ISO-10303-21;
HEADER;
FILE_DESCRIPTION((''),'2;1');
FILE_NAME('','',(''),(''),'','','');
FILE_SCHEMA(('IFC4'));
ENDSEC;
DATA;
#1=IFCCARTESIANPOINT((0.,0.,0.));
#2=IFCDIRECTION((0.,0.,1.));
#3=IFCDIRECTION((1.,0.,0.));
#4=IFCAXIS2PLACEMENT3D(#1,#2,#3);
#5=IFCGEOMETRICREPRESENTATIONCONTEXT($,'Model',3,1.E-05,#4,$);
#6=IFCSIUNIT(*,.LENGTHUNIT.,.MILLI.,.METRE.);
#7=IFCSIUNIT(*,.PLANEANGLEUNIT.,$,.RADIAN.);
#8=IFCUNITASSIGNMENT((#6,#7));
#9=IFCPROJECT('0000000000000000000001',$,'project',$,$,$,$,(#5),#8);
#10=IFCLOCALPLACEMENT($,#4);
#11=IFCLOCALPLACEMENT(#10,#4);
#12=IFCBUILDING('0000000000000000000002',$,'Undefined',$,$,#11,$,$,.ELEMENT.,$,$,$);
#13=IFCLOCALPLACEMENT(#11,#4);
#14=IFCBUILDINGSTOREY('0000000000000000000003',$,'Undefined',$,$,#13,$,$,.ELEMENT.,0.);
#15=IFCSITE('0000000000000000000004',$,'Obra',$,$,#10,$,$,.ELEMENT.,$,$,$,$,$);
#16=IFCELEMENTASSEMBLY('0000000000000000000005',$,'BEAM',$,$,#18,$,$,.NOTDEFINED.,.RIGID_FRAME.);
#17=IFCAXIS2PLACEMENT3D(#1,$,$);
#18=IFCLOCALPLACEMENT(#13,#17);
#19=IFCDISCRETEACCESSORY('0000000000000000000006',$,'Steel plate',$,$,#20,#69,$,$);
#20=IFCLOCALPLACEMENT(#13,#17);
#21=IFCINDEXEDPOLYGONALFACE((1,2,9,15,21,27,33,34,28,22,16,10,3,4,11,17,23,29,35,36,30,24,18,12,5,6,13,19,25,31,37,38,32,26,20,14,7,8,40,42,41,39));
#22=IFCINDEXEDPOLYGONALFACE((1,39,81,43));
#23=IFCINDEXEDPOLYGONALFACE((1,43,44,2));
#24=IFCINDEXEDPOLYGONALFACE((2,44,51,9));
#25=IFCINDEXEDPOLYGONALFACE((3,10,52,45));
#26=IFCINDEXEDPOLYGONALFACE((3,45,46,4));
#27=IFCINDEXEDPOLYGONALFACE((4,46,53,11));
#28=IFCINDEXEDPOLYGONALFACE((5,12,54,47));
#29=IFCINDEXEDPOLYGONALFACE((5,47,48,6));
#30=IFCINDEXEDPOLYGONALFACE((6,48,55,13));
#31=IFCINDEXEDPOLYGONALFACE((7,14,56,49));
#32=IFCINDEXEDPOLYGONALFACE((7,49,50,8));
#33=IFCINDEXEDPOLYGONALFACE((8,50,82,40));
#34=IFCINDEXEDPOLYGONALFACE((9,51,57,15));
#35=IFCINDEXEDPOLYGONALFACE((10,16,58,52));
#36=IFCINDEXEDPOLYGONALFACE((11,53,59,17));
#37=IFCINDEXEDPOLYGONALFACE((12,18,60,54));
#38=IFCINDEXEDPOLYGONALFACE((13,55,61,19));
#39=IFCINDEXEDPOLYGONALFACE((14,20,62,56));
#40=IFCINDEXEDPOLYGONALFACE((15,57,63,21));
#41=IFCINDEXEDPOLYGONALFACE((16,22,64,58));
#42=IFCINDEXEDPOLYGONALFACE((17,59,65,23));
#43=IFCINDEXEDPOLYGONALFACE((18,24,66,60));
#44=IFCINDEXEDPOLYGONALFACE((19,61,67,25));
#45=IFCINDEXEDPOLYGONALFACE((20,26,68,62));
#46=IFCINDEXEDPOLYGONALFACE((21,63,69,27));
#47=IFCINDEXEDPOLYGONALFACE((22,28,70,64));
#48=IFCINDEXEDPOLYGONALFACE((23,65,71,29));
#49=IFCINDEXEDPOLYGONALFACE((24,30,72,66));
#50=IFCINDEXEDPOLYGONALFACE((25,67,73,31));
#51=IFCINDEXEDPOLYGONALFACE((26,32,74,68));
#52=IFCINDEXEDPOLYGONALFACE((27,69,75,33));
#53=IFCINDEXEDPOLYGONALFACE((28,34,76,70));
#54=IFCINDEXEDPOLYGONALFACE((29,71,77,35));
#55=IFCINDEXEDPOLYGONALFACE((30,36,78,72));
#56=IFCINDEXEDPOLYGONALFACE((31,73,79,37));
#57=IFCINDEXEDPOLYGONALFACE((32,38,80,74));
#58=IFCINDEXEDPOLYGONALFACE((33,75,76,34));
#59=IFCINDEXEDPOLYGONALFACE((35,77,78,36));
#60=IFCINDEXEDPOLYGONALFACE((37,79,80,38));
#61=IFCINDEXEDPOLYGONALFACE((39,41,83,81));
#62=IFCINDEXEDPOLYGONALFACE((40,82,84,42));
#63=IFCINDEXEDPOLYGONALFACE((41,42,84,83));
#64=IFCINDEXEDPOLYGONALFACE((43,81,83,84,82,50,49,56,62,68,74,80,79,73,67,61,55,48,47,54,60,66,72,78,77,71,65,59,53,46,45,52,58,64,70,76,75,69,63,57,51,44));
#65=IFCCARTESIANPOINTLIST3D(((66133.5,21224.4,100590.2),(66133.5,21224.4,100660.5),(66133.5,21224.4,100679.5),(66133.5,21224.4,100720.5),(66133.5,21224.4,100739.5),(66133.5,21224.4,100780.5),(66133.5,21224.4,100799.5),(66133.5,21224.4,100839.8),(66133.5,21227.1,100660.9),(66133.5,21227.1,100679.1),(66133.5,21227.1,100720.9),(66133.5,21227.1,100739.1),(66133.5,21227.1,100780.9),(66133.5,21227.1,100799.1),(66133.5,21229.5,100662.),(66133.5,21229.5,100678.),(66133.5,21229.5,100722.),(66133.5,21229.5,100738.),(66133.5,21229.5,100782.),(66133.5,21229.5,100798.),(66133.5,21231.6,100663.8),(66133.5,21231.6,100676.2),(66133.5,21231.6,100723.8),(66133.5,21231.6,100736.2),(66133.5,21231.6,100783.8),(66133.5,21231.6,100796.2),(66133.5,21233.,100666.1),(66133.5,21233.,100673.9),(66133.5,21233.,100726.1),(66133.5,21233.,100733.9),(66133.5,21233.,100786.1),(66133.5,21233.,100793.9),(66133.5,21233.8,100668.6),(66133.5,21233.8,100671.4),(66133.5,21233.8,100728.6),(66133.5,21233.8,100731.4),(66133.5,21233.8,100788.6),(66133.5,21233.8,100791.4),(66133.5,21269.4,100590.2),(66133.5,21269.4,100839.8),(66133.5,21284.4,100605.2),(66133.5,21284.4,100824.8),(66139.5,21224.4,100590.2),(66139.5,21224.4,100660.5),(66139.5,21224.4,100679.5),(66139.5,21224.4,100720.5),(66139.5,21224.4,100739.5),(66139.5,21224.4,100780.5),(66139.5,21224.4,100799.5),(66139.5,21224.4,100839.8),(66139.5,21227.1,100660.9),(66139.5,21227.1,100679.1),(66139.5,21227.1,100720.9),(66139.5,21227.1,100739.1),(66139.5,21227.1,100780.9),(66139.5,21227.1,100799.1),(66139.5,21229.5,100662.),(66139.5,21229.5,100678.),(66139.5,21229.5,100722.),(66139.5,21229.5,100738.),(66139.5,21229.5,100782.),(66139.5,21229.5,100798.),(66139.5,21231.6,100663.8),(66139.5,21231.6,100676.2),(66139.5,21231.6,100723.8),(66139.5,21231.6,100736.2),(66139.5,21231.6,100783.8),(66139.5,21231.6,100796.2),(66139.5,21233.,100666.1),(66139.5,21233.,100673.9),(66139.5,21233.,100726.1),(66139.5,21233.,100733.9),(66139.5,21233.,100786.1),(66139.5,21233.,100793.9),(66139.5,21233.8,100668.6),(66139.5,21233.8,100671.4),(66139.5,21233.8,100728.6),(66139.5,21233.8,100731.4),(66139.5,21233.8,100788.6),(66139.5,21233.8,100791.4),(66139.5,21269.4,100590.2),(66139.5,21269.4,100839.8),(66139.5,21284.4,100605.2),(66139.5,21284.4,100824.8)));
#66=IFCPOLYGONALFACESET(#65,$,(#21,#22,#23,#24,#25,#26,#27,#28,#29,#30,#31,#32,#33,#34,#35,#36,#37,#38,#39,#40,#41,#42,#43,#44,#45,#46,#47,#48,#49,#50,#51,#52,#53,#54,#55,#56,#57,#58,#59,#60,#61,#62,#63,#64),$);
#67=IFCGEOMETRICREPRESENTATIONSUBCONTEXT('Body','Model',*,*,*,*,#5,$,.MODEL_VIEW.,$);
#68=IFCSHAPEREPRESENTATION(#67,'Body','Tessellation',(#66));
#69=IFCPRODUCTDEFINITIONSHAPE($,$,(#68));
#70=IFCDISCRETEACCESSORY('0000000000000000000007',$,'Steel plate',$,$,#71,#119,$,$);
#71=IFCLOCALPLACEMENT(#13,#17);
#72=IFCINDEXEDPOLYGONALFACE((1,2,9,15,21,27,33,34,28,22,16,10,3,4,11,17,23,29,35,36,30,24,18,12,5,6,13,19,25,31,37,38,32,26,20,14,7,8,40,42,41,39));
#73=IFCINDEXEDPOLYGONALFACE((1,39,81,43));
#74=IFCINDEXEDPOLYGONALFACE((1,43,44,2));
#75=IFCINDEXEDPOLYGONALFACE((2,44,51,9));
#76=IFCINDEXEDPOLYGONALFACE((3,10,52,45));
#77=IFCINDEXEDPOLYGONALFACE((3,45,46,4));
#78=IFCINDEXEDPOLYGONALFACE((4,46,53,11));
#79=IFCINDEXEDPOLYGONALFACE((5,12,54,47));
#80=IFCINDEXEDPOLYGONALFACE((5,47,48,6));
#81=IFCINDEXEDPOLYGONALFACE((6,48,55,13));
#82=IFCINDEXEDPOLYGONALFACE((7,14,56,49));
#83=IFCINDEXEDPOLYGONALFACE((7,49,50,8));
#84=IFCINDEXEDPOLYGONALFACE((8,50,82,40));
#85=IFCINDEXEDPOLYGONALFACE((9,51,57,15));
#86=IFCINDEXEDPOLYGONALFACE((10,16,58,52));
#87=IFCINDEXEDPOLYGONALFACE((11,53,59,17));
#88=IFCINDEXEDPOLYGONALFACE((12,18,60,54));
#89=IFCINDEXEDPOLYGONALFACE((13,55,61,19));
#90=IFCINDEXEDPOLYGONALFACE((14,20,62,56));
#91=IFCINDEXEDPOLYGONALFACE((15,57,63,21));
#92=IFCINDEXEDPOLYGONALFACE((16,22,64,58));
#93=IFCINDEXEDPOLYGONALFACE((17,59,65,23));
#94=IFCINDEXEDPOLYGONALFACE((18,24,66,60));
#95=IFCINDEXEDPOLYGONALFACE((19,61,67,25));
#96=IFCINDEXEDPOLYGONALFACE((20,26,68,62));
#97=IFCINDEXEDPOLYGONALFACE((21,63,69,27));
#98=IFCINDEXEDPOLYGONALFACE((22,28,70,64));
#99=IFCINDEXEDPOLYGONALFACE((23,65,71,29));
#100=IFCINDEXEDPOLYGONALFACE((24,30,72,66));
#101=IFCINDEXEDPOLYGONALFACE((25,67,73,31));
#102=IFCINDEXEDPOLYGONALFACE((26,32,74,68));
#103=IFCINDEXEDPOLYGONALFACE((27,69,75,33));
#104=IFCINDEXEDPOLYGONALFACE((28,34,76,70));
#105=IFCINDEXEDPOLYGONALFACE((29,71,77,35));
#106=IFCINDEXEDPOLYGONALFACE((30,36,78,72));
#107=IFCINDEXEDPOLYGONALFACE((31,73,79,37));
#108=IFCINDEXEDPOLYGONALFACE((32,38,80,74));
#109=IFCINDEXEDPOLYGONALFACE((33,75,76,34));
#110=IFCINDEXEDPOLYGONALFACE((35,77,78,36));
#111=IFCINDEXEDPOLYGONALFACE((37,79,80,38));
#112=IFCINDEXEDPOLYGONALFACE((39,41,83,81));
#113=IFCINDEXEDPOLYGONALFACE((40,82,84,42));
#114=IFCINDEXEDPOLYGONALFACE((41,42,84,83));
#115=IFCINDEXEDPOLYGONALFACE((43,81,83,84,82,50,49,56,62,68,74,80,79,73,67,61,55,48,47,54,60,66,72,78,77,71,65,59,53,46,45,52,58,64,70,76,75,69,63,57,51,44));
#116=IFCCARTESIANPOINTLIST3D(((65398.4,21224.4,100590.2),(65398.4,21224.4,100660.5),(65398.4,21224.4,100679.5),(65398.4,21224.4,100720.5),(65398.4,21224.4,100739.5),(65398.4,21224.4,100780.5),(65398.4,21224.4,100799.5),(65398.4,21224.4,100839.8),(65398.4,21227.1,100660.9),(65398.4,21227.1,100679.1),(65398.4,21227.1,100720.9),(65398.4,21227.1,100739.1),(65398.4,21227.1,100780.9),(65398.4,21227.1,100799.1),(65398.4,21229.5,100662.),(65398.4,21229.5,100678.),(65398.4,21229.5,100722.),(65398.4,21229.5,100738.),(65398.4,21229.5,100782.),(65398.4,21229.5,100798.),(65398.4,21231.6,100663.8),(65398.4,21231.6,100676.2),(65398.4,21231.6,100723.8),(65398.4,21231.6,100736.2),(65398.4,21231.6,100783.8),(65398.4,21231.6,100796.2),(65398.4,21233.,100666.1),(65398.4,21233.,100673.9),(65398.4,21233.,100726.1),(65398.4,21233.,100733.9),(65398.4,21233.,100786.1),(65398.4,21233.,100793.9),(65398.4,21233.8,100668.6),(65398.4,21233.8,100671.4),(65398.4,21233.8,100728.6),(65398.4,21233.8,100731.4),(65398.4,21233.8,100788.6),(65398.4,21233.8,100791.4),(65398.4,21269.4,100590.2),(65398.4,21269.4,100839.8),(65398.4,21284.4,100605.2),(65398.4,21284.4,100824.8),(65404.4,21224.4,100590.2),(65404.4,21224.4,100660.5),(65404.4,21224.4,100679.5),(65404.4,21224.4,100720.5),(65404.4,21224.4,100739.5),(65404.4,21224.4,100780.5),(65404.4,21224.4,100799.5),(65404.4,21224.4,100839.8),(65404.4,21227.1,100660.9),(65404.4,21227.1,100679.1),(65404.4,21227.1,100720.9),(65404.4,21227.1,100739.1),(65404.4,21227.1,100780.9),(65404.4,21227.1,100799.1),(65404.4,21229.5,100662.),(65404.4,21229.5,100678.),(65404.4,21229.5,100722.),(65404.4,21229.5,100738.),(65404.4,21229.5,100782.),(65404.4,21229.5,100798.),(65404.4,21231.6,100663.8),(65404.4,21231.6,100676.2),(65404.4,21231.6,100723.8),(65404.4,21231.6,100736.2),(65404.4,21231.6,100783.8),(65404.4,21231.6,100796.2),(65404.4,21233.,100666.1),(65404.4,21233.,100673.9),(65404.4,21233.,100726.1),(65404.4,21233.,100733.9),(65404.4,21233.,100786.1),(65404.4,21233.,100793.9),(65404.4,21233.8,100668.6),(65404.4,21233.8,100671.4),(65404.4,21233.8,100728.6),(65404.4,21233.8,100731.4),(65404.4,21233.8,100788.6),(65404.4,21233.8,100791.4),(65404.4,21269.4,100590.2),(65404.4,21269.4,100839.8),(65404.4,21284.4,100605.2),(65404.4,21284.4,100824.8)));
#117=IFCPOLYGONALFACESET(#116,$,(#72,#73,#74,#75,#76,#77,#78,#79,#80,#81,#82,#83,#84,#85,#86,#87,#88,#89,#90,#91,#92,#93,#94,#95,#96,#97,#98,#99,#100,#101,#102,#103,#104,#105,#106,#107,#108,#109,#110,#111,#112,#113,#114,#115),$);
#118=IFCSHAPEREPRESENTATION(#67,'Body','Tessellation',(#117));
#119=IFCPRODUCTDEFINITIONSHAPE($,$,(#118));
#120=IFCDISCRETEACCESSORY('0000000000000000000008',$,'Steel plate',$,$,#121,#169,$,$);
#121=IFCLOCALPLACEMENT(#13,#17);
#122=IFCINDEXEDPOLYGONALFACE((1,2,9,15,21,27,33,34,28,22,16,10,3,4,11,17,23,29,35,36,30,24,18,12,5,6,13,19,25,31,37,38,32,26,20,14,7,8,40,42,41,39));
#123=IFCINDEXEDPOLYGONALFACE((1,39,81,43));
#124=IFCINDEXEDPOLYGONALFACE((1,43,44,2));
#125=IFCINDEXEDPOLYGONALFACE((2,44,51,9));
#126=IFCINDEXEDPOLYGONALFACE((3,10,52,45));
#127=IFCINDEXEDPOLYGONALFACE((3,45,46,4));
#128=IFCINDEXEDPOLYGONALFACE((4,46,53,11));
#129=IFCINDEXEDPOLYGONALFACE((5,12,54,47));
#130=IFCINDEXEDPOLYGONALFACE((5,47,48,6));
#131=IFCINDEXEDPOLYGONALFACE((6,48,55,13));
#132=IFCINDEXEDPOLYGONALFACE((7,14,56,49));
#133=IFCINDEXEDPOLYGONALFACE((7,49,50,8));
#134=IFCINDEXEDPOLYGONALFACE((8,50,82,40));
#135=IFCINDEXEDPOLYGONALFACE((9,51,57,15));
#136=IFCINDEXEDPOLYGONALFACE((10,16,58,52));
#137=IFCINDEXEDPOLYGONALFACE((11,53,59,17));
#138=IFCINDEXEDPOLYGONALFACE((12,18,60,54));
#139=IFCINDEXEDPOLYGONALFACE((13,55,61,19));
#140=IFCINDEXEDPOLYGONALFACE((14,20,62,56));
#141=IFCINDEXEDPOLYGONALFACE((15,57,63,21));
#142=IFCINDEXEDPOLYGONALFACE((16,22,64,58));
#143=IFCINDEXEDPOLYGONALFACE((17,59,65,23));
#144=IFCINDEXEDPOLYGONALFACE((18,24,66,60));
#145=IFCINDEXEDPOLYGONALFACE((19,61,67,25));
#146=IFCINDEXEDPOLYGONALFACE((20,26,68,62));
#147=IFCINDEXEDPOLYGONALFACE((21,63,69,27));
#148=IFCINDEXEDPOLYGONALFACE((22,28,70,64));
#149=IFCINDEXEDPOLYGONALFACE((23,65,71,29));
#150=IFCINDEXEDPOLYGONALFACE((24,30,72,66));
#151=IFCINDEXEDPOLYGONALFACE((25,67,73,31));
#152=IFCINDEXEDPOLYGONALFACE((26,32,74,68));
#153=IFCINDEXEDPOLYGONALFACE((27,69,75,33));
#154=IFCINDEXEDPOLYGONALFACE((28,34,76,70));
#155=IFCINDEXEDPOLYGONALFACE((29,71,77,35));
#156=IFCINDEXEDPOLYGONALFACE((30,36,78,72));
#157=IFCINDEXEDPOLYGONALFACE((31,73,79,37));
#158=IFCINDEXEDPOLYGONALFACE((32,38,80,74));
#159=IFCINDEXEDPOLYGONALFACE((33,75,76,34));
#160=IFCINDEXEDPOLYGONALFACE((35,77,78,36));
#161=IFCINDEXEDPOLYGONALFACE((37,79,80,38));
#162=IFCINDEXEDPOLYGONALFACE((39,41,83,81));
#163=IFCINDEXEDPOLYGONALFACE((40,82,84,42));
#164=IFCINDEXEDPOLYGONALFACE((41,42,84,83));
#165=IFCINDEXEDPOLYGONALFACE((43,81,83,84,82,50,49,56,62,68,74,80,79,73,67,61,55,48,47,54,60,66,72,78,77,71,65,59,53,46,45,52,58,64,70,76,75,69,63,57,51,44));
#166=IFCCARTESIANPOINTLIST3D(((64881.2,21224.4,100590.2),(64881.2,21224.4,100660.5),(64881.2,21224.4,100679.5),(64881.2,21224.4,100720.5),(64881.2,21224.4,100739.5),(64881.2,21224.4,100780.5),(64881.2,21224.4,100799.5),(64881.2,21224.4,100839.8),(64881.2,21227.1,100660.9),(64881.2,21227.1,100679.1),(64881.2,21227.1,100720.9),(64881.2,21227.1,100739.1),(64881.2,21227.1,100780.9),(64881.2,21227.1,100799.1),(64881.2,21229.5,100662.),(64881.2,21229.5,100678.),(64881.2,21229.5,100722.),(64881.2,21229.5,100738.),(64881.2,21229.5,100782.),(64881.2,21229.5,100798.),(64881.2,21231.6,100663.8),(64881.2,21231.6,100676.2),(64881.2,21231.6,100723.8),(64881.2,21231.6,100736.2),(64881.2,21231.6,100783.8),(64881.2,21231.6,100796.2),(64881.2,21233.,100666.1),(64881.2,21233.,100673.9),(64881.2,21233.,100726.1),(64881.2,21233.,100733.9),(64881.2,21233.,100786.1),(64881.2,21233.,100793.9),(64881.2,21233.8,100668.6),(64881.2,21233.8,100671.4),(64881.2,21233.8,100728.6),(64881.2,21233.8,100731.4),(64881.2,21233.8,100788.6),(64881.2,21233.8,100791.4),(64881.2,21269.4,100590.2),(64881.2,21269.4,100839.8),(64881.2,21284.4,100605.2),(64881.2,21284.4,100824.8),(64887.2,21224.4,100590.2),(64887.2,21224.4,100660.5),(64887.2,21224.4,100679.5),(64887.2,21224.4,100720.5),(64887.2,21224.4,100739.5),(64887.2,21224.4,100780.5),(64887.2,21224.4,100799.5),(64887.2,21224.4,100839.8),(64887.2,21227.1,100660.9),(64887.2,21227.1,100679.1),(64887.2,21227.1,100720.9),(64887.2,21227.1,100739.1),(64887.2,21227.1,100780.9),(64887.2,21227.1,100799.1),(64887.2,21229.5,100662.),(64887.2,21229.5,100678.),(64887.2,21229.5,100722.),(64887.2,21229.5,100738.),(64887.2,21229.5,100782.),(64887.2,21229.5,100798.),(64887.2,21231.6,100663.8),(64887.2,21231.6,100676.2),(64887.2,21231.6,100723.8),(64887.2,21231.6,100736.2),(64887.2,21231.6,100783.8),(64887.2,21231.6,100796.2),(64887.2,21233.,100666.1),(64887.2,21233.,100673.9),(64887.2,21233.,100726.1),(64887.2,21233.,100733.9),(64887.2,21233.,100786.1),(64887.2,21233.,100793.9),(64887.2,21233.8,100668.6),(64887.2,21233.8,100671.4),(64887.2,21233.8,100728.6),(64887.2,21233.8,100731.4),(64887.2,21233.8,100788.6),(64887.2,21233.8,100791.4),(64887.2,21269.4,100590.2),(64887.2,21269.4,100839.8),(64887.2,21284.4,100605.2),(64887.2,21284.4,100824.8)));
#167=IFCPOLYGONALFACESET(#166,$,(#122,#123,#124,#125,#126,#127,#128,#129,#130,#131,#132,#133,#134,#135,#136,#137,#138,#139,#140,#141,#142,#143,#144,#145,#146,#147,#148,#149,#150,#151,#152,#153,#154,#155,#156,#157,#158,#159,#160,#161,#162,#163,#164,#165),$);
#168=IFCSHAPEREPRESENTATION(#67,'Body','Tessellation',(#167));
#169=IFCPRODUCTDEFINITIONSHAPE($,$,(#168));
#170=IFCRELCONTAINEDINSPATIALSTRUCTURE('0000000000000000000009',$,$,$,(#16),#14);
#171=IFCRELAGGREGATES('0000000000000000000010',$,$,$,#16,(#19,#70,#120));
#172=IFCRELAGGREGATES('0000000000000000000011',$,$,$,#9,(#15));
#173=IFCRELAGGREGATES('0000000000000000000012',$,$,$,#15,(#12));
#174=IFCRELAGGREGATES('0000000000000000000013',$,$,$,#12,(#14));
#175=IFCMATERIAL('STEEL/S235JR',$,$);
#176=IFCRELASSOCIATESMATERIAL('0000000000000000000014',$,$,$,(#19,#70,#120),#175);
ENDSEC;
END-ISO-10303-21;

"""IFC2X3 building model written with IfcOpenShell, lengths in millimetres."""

from ifc_helpers import new_model, si_unit, frame, origin_with_axes, origin_2d_with_axis, place, context, subcontext, project, spatial, polyline, circle, outline, extrude, source, transform, mapped, material, element, aggregate, save


model = new_model("IFC2X3")

# Units and contexts
model_context = context("Model", 3, precision=1e-05, world=origin_with_axes())
body_context = subcontext(model_context, "Body", "Model", "MODEL_VIEW")
ifc_project = project(units=[si_unit("LENGTHUNIT", "METRE", prefix="MILLI"), si_unit("PLANEANGLEUNIT", "RADIAN")], contexts=[model_context])

# Site, building, storey
site_placement = place(None, origin_with_axes())
site = spatial("IfcSite", under=ifc_project, at=site_placement, Name="Obra", CompositionType="ELEMENT")
building_placement = place(site_placement, origin_with_axes())
building = spatial("IfcBuilding", under=site, at=building_placement, Name="Undefined", CompositionType="ELEMENT")
storey_placement = place(building_placement, origin_with_axes())
storey = spatial("IfcBuildingStorey", under=building, at=storey_placement, Name="Undefined", CompositionType="ELEMENT", Elevation=0.0)

# Shared definitions
ifc_material = material(Name="STEEL/S235JR")

# Element assembly, discrete accessories, openings
shared_shape_1 = source(origin_with_axes(), body_context, "Body", "SweptSolid", [
    extrude(circle(Radius=9.5, at=origin_2d_with_axis()), frame((0.0, -9.2, 0.0), z_axis=(0.0, 1.0, 0.0), x_axis=(1.0, 0.0, 0.0)), (0.0, 0.0, 1.0), 6.2),
])
assembly_1_placement = place(storey_placement, origin_with_axes())
assembly_1 = element("IfcElementAssembly", 1, at=assembly_1_placement, inside=storey, Name="BEAM", AssemblyPlace="NOTDEFINED", PredefinedType="RIGID_FRAME")
discrete_accessory_1_placement = place(assembly_1_placement, frame((66136.5, 21224.4, 100590.2), z_axis=(1.0, 0.000001, 0.0), x_axis=(-0.000002, 1.0, 0.0)))
discrete_accessory_1 = element("IfcDiscreteAccessory", 2, at=discrete_accessory_1_placement, material=ifc_material, Name="Steel plate", context=body_context, shape_type="SweptSolid", body=[
    extrude(outline(polyline([(0.0, 0.0), (45.0, 0.0), (60.0, 15.0), (60.0, 234.6), (45.0, 249.6), (0.0, 249.6), (0.0, 0.0)])), frame((0.0, 0.0, -3.0), z_axis=(0.0, 0.0, 1.0), x_axis=(1.0, 0.0, 0.0)), (0.0, 0.0, 1.0), 6.0),
])
opening_1_placement = place(assembly_1_placement, frame((66142.6, 21274.4, 100850.0), z_axis=(0.000002, -1.0, 0.0), x_axis=(0.0, 0.0, -1.0)))
element("IfcOpeningElement", 3, at=opening_1_placement, cuts=discrete_accessory_1, ObjectType="Opening", context=body_context, shape_type="MappedRepresentation", body=[
    mapped(shared_shape_1, transform((60.0, 0.0, 50.0))),
    mapped(shared_shape_1, transform((120.0, 0.0, 50.0))),
    mapped(shared_shape_1, transform((180.0, 0.0, 50.0))),
])
discrete_accessory_2_placement = place(assembly_1_placement, frame((65401.4, 21224.4, 100590.2), z_axis=(1.0, 0.000001, 0.0), x_axis=(-0.000002, 1.0, 0.0)))
discrete_accessory_2 = element("IfcDiscreteAccessory", 4, at=discrete_accessory_2_placement, material=ifc_material, Name="Steel plate", context=body_context, shape_type="SweptSolid", body=[
    extrude(outline(polyline([(0.0, 0.0), (45.0, 0.0), (60.0, 15.0), (60.0, 234.6), (45.0, 249.6), (0.0, 249.6), (0.0, 0.0)])), frame((0.0, 0.0, -3.0), z_axis=(0.0, 0.0, 1.0), x_axis=(1.0, 0.0, 0.0)), (0.0, 0.0, 1.0), 6.0),
])
opening_2_placement = place(assembly_1_placement, frame((65407.5, 21274.4, 100850.0), z_axis=(0.000002, -1.0, 0.0), x_axis=(0.0, 0.0, -1.0)))
element("IfcOpeningElement", 5, at=opening_2_placement, cuts=discrete_accessory_2, ObjectType="Opening", context=body_context, shape_type="MappedRepresentation", body=[
    mapped(shared_shape_1, transform((60.0, 0.0, 50.0))),
    mapped(shared_shape_1, transform((120.0, 0.0, 50.0))),
    mapped(shared_shape_1, transform((180.0, 0.0, 50.0))),
])
discrete_accessory_3_placement = place(assembly_1_placement, frame((64884.2, 21224.4, 100590.2), z_axis=(1.0, 0.000001, 0.0), x_axis=(-0.000002, 1.0, 0.0)))
discrete_accessory_3 = element("IfcDiscreteAccessory", 6, at=discrete_accessory_3_placement, material=ifc_material, Name="Steel plate", context=body_context, shape_type="SweptSolid", body=[
    extrude(outline(polyline([(0.0, 0.0), (45.0, 0.0), (60.0, 15.0), (60.0, 234.6), (45.0, 249.6), (0.0, 249.6), (0.0, 0.0)])), frame((0.0, 0.0, -3.0), z_axis=(0.0, 0.0, 1.0), x_axis=(1.0, 0.0, 0.0)), (0.0, 0.0, 1.0), 6.0),
])
opening_3_placement = place(assembly_1_placement, frame((64890.3, 21274.4, 100850.0), z_axis=(0.000002, -1.0, 0.0), x_axis=(0.0, 0.0, -1.0)))
element("IfcOpeningElement", 7, at=opening_3_placement, cuts=discrete_accessory_3, ObjectType="Opening", context=body_context, shape_type="MappedRepresentation", body=[
    mapped(shared_shape_1, transform((60.0, 0.0, 50.0))),
    mapped(shared_shape_1, transform((120.0, 0.0, 50.0))),
    mapped(shared_shape_1, transform((180.0, 0.0, 50.0))),
])
aggregate(assembly_1, [discrete_accessory_1, discrete_accessory_2, discrete_accessory_3])

save(model, "model.ifc")
